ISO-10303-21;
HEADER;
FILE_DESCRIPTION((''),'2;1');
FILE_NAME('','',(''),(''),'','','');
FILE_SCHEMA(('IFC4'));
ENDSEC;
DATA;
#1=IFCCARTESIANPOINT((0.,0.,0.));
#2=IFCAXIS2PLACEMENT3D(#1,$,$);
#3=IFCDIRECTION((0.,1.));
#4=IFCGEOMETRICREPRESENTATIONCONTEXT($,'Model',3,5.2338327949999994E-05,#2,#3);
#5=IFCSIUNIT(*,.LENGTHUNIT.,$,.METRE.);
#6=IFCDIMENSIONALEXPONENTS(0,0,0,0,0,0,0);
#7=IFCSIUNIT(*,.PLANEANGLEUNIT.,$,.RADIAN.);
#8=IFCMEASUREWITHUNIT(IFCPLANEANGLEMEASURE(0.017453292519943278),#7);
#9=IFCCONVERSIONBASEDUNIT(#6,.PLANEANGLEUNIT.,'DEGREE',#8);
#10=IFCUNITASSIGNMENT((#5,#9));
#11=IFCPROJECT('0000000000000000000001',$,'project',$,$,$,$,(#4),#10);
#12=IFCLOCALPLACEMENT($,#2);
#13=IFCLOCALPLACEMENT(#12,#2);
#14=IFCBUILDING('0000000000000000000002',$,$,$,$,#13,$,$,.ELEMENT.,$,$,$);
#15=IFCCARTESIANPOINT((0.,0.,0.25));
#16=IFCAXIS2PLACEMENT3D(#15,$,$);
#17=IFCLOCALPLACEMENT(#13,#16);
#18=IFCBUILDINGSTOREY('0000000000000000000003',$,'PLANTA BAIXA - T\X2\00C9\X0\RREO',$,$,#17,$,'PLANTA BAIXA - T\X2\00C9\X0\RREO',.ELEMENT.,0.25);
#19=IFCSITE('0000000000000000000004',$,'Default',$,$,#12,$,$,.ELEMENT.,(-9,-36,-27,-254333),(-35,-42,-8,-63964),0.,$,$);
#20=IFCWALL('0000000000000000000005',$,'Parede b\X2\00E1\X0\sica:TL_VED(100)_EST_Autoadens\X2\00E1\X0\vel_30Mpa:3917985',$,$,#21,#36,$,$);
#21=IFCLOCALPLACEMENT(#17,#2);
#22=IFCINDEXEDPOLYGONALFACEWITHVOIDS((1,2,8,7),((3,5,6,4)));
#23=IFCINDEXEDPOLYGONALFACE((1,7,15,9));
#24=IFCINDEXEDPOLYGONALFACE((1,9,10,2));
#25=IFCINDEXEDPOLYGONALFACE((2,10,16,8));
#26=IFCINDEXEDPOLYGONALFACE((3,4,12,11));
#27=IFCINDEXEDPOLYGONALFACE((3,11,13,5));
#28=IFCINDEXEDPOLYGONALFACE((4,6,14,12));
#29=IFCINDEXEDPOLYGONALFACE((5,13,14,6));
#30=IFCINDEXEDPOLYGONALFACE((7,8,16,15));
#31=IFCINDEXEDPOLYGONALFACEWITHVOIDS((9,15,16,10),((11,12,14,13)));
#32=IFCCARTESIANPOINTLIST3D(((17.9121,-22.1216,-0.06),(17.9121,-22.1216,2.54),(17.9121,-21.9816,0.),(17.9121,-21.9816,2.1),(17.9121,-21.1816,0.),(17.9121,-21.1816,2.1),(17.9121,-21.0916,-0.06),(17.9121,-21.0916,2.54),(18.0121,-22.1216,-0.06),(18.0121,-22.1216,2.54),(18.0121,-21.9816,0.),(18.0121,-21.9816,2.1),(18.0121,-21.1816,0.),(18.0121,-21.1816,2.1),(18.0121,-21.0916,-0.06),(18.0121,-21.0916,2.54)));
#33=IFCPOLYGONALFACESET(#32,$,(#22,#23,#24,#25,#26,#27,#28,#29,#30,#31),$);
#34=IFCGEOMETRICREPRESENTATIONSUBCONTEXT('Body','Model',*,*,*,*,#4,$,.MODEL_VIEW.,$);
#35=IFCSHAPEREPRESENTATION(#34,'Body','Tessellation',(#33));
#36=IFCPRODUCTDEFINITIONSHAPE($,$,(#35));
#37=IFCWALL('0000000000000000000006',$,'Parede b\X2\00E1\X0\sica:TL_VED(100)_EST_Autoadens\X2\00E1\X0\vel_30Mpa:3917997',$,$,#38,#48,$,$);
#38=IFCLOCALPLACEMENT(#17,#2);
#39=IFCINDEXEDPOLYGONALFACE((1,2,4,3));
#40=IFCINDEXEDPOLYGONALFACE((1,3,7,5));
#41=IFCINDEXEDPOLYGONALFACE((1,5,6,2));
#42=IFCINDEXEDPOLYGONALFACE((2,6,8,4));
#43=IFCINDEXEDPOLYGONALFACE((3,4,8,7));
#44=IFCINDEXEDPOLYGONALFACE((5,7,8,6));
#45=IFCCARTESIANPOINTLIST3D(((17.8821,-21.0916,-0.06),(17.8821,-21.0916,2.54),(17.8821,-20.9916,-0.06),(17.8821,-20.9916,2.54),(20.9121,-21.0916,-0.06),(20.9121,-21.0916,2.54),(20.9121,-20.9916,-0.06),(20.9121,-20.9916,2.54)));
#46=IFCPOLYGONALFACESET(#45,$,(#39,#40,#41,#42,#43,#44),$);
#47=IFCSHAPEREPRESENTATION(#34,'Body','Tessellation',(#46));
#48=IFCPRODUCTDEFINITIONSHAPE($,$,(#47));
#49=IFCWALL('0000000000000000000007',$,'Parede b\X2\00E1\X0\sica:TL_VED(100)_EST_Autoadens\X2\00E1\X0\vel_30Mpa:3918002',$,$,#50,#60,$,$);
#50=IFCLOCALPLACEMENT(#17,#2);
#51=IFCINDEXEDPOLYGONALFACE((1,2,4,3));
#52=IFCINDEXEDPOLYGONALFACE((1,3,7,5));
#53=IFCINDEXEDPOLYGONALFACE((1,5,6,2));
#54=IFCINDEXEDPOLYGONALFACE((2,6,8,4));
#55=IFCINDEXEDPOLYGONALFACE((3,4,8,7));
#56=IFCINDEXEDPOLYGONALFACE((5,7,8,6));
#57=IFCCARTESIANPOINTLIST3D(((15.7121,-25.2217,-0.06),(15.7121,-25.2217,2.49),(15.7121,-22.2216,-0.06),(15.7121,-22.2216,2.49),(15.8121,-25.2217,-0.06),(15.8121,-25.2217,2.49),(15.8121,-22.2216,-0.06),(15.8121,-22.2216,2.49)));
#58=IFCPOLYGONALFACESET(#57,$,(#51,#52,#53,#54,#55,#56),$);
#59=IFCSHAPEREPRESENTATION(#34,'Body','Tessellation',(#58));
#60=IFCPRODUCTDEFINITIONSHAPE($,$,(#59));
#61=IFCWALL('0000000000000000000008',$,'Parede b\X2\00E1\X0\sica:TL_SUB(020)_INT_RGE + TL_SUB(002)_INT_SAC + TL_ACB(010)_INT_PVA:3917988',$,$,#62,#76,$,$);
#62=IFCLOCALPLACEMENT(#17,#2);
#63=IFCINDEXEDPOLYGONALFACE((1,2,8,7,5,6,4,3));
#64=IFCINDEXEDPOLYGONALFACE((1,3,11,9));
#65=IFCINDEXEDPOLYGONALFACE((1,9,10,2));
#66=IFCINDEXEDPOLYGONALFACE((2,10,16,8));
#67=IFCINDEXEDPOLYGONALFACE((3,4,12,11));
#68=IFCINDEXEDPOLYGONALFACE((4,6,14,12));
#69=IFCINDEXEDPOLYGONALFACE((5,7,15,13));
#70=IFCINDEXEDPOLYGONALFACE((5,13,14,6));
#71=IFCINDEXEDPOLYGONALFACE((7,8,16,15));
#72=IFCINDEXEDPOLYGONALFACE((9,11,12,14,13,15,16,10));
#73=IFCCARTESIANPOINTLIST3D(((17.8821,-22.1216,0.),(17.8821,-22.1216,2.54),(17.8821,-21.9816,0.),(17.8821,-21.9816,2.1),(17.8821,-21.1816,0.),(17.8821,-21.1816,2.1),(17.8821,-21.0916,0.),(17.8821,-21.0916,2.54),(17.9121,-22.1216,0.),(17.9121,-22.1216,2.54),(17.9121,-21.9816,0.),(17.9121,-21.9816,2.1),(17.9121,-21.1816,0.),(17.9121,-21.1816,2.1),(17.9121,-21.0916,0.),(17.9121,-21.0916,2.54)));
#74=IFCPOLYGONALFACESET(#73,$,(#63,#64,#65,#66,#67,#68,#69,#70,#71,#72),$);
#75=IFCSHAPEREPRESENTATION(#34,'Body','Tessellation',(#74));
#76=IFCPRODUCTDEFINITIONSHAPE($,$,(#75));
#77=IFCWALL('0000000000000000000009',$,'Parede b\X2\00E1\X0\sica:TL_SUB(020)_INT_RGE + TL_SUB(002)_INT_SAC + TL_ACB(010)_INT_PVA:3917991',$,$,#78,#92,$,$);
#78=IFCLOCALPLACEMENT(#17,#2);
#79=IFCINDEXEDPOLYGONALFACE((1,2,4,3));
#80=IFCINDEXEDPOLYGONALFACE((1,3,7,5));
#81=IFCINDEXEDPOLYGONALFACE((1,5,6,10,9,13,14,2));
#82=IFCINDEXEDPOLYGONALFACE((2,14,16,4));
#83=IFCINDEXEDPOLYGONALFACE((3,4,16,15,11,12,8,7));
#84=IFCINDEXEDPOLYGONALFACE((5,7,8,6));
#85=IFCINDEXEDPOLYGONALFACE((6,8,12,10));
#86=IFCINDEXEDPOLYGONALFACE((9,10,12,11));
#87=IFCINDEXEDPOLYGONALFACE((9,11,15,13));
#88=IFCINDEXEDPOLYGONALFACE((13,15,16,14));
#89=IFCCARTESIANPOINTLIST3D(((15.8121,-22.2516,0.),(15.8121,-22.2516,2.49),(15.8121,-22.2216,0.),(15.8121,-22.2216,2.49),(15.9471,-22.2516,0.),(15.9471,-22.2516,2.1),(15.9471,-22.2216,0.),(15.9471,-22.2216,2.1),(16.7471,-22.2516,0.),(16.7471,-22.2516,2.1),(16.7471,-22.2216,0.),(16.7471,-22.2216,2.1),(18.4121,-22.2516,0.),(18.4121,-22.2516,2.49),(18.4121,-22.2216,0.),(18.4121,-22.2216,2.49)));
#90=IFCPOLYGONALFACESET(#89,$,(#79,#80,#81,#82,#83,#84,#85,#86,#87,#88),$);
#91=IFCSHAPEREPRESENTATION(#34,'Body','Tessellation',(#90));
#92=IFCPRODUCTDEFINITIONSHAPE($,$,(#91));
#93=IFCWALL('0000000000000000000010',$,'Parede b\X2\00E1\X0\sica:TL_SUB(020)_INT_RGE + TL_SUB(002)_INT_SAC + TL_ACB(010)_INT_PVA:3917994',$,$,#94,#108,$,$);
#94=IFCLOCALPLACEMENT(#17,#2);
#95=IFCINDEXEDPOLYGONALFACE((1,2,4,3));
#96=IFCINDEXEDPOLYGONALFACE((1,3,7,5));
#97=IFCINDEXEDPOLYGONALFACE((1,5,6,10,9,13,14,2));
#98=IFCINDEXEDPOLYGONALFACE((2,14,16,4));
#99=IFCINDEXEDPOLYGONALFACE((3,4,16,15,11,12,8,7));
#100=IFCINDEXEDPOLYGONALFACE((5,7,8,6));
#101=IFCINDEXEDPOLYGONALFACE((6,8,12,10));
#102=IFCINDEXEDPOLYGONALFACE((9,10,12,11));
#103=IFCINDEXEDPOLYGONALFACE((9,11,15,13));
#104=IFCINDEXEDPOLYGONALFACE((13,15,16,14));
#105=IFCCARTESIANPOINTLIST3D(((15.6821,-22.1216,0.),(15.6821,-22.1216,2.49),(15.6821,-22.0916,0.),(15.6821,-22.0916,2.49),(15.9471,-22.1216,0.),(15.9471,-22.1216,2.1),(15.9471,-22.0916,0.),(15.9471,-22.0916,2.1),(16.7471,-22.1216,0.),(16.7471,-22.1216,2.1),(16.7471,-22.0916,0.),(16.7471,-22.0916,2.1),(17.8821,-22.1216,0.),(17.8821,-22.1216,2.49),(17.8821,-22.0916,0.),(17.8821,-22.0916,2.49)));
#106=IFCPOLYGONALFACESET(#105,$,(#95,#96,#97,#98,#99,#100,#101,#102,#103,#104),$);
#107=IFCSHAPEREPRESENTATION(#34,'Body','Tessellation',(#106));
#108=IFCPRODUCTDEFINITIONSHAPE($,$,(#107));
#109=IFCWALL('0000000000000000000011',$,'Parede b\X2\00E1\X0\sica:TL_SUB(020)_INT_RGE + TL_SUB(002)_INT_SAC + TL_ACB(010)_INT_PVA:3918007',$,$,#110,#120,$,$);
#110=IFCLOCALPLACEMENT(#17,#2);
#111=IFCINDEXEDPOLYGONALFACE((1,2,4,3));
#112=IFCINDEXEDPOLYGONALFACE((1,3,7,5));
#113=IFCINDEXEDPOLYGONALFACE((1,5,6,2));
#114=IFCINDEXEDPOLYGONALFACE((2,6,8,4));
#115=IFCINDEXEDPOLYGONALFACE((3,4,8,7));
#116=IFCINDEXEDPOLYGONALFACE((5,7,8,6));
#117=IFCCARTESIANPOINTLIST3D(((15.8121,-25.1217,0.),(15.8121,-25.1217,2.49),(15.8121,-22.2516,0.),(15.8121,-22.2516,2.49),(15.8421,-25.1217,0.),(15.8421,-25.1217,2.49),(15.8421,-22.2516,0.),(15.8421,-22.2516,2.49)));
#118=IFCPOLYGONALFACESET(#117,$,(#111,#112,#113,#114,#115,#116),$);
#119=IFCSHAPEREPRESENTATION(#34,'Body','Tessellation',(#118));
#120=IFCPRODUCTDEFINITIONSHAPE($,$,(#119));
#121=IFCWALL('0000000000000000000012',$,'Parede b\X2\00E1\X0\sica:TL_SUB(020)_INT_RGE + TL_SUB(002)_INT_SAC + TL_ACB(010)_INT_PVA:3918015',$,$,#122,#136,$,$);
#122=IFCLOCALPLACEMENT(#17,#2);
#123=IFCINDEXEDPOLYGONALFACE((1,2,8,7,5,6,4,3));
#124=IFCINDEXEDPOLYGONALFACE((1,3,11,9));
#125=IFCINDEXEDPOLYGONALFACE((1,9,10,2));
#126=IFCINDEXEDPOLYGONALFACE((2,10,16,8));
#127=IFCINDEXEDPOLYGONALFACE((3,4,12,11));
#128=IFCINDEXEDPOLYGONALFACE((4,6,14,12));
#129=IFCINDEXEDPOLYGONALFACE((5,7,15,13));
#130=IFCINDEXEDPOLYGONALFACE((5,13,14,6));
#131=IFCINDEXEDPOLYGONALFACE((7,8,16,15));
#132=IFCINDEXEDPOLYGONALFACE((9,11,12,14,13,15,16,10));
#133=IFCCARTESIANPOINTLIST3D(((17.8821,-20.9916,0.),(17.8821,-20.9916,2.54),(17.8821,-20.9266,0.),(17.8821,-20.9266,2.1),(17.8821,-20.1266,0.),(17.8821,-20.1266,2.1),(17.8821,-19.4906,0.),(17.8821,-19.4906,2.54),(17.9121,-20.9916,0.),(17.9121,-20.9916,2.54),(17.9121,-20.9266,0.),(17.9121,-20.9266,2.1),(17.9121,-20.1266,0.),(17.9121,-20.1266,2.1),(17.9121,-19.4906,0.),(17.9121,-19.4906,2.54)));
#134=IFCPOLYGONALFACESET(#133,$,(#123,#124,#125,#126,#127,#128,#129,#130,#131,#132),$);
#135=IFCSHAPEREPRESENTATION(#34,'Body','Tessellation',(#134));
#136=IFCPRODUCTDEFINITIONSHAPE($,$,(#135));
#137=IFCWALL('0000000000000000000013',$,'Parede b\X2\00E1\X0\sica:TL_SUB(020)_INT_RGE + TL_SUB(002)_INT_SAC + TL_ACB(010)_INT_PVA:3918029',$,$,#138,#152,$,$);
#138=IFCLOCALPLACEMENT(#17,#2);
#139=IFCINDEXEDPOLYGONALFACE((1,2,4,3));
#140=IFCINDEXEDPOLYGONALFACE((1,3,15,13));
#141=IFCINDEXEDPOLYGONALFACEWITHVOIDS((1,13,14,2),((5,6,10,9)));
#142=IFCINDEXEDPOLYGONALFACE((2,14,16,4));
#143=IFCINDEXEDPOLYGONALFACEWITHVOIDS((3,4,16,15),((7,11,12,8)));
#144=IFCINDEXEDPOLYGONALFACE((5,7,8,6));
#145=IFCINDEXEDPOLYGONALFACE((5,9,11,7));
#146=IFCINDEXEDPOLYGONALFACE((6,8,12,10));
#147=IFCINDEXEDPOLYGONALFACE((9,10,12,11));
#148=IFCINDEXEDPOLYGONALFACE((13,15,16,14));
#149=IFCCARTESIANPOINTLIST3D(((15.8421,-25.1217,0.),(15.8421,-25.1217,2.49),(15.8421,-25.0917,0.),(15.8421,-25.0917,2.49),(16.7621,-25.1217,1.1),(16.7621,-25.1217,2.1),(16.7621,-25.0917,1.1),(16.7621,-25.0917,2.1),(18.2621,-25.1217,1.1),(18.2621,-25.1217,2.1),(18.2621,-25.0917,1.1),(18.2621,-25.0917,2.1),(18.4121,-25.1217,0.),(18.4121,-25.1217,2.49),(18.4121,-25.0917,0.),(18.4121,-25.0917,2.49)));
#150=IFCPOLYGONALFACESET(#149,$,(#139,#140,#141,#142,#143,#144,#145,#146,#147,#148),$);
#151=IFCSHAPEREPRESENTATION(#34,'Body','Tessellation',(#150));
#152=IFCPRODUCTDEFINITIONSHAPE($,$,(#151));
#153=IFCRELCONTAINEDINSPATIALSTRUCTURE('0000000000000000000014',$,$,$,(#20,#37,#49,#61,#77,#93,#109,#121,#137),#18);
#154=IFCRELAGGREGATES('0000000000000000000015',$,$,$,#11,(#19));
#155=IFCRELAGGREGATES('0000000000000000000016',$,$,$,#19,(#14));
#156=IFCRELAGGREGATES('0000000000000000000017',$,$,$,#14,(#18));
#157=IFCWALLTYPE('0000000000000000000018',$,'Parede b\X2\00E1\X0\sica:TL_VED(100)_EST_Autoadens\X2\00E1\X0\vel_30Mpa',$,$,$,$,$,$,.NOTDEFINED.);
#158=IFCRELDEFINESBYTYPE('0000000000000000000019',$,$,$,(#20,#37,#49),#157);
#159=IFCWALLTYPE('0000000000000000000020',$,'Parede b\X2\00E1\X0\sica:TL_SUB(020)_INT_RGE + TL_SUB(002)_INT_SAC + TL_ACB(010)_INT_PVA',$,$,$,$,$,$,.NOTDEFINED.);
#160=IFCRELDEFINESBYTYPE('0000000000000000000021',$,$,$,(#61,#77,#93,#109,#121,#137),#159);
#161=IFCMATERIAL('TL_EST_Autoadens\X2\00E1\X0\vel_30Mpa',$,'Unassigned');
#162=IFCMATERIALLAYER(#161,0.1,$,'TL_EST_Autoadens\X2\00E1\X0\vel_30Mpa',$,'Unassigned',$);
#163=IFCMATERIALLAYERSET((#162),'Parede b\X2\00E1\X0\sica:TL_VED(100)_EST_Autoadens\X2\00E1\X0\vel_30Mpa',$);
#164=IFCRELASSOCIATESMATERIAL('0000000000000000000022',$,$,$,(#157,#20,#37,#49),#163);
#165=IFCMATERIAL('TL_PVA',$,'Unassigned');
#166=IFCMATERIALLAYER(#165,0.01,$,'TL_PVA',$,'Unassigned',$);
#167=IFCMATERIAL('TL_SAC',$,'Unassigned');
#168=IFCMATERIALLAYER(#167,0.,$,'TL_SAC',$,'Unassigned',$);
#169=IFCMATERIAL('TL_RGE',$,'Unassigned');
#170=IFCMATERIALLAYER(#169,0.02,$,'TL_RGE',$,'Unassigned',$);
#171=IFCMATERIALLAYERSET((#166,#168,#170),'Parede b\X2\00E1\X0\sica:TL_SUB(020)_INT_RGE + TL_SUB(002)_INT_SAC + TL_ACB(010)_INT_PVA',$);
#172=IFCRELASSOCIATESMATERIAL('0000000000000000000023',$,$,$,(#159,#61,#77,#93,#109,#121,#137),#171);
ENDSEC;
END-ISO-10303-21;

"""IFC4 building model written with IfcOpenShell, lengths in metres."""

from ifc_helpers import new_model, entity, si_unit, converted_unit, direction, frame, frame_2d, origin, place, context, subcontext, project, spatial, rectangle, extrude, material, layer, layer_set, layer_usage, type_object, element, save


model = new_model("IFC4")

# Units and contexts
model_context = context("Model", 3, precision=5.2338327949999994e-05, world=origin(), true_north=direction((0.0, 1.0)))
body_context = subcontext(model_context, "Body", "Model", "MODEL_VIEW")
ifc_project = project(units=[si_unit("LENGTHUNIT", "METRE"), converted_unit("PLANEANGLEUNIT", "DEGREE", entity("IfcPlaneAngleMeasure", 0.017453292519943278), si_unit("PLANEANGLEUNIT", "RADIAN"), dimensions=[0, 0, 0, 0, 0, 0, 0])], contexts=[model_context])

# Site, building, storey
site_placement = place(None, frame((0.0, 0.0, 0.0)))
site = spatial("IfcSite", under=ifc_project, at=site_placement, Name="Default", CompositionType="ELEMENT", RefLatitude=(-9, -36, -27, -254333), RefLongitude=(-35, -42, -8, -63964), RefElevation=0.0)
building_placement = place(site_placement, origin())
building = spatial("IfcBuilding", under=site, at=building_placement, CompositionType="ELEMENT")
storey_placement = place(building_placement, frame((0.0, 0.0, 0.25)))
storey = spatial("IfcBuildingStorey", under=building, at=storey_placement, Name="PLANTA BAIXA - TÉRREO", LongName="PLANTA BAIXA - TÉRREO", CompositionType="ELEMENT", Elevation=0.25)

# Wall, opening
ifc_material_1 = material(Name="TL_EST_Autoadensável_30Mpa", Category="Unassigned")
ifc_layer_1 = layer(ifc_material_1, 0.1, Name="TL_EST_Autoadensável_30Mpa", Category="Unassigned")
ifc_layer_set_1 = layer_set([ifc_layer_1], Name="Parede básica:TL_VED(100)_EST_Autoadensável_30Mpa")
ifc_layer_usage_1 = layer_usage(ifc_layer_set_1, "AXIS2", "POSITIVE", -0.05)
wall_type_1 = type_object("IfcWallType", Name="Parede básica:TL_VED(100)_EST_Autoadensável_30Mpa", PredefinedType="NOTDEFINED", material=ifc_layer_set_1)
wall_1_placement = place(storey_placement, frame((17.9621, -22.1216, -0.06), z_axis=(0.0, 0.0, 1.0), x_axis=(0.0, 1.0, 0.0)))
wall_1 = element("IfcWall", 1, at=wall_1_placement, inside=storey, type_object=wall_type_1, material=ifc_layer_usage_1, Name="Parede básica:TL_VED(100)_EST_Autoadensável_30Mpa:3917985", context=body_context, shape_type="SweptSolid", body=[
    extrude(rectangle(XDim=1.03, YDim=0.1, at=frame_2d((0.515, 0.0), x_axis=(-1.0, 0.0))), origin(), (0.0, 0.0, 1.0), 2.6),
])
opening_1_placement = place(wall_1_placement, frame((0.94, 0.05, 0.06)))
element("IfcOpeningElement", 2, at=opening_1_placement, cuts=wall_1, PredefinedType="OPENING", context=body_context, shape_type="SweptSolid", body=[
    extrude(rectangle(XDim=2.1, YDim=0.8, at=frame_2d((1.05, 0.4), x_axis=(1.0, 0.0))), frame((0.0, 0.0, 0.0), z_axis=(0.0, -1.0, 0.0), x_axis=(0.0, 0.0, 1.0)), (0.0, 0.0, 1.0), 0.1),
])

# Wall
ifc_layer_usage_2 = layer_usage(ifc_layer_set_1, "AXIS2", "NEGATIVE", 0.05)
wall_2_placement = place(storey_placement, frame((17.8821, -21.0416, -0.06)))
element("IfcWall", 3, at=wall_2_placement, inside=storey, type_object=wall_type_1, material=ifc_layer_usage_2, Name="Parede básica:TL_VED(100)_EST_Autoadensável_30Mpa:3917997", context=body_context, shape_type="SweptSolid", body=[
    extrude(rectangle(XDim=3.03, YDim=0.1, at=frame_2d((1.515, 0.0), x_axis=(-1.0, 0.0))), origin(), (0.0, 0.0, 1.0), 2.6),
])

# Walls, openings
ifc_layer_usage_3 = layer_usage(ifc_layer_set_1, "AXIS2", "NEGATIVE", 0.05)
wall_3_placement = place(storey_placement, frame((15.7621, -25.2217, -0.06), z_axis=(0.0, 0.0, 1.0), x_axis=(0.0, 1.0, 0.0)))
wall_3 = element("IfcWall", 4, at=wall_3_placement, inside=storey, type_object=wall_type_1, material=ifc_layer_usage_3, Name="Parede básica:TL_VED(100)_EST_Autoadensável_30Mpa:3918002", context=body_context, shape_type="SweptSolid", body=[
    extrude(rectangle(XDim=3.0001, YDim=0.1, at=frame_2d((1.5001, 0.0), x_axis=(-1.0, 0.0))), origin(), (0.0, 0.0, 1.0), 2.55),
])
opening_2_placement = place(wall_3_placement, frame((25.2217, 15.7621, 0.06)))
element("IfcOpeningElement", 5, at=opening_2_placement, cuts=wall_3, PredefinedType="OPENING", context=body_context, shape_type="SweptSolid", body=[
    extrude(rectangle(XDim=2.1, YDim=0.1, at=frame_2d((0.0, 0.0), x_axis=(0.0, 1.0))), frame((-24.2717, -15.7121, 1.05), z_axis=(0.0, 1.0, 0.0), x_axis=(1.0, 0.0, 0.0)), (0.0, 0.0, 1.0), 2.4),
])
ifc_material_2 = material(Name="TL_PVA", Category="Unassigned")
ifc_layer_2 = layer(ifc_material_2, 0.01, Name="TL_PVA", Category="Unassigned")
ifc_material_3 = material(Name="TL_SAC", Category="Unassigned")
ifc_layer_3 = layer(ifc_material_3, 0.0, Name="TL_SAC", Category="Unassigned")
ifc_material_4 = material(Name="TL_RGE", Category="Unassigned")
ifc_layer_4 = layer(ifc_material_4, 0.02, Name="TL_RGE", Category="Unassigned")
ifc_layer_set_2 = layer_set([ifc_layer_2, ifc_layer_3, ifc_layer_4], Name="Parede básica:TL_SUB(020)_INT_RGE + TL_SUB(002)_INT_SAC + TL_ACB(010)_INT_PVA")
ifc_layer_usage_4 = layer_usage(ifc_layer_set_2, "AXIS2", "POSITIVE", -0.015)
wall_type_2 = type_object("IfcWallType", Name="Parede básica:TL_SUB(020)_INT_RGE + TL_SUB(002)_INT_SAC + TL_ACB(010)_INT_PVA", PredefinedType="NOTDEFINED", material=ifc_layer_set_2)
wall_4_placement = place(storey_placement, frame((17.8971, -21.0916, 0.0), z_axis=(0.0, 0.0, 1.0), x_axis=(0.0, -1.0, 0.0)))
wall_4 = element("IfcWall", 6, at=wall_4_placement, inside=storey, type_object=wall_type_2, material=ifc_layer_usage_4, Name="Parede básica:TL_SUB(020)_INT_RGE + TL_SUB(002)_INT_SAC + TL_ACB(010)_INT_PVA:3917988", context=body_context, shape_type="SweptSolid", body=[
    extrude(rectangle(XDim=1.03, YDim=0.03, at=frame_2d((0.515, 0.0), x_axis=(-1.0, 0.0))), origin(), (0.0, 0.0, 1.0), 2.54),
])
opening_3_placement = place(wall_4_placement, frame((-21.0916, -17.8971, 0.0)))
element("IfcOpeningElement", 7, at=opening_3_placement, cuts=wall_4, PredefinedType="OPENING", context=body_context, shape_type="SweptSolid", body=[
    extrude(rectangle(XDim=2.1, YDim=0.8, at=frame_2d((0.0, 0.0), x_axis=(1.0, 0.0))), frame((21.5816, 16.3881, 1.05), z_axis=(0.0, 1.0, 0.0), x_axis=(0.0, 0.0, 1.0)), (0.0, 0.0, 1.0), 3.048),
])
ifc_layer_usage_5 = layer_usage(ifc_layer_set_2, "AXIS2", "POSITIVE", -0.015)
wall_5_placement = place(storey_placement, frame((15.8121, -22.2366, 0.0)))
wall_5 = element("IfcWall", 8, at=wall_5_placement, inside=storey, type_object=wall_type_2, material=ifc_layer_usage_5, Name="Parede básica:TL_SUB(020)_INT_RGE + TL_SUB(002)_INT_SAC + TL_ACB(010)_INT_PVA:3917991", context=body_context, shape_type="SweptSolid", body=[
    extrude(rectangle(XDim=2.6, YDim=0.03, at=frame_2d((1.3, 0.0), x_axis=(-1.0, 0.0))), origin(), (0.0, 0.0, 1.0), 2.49),
])
opening_4_placement = place(wall_5_placement, frame((-15.8121, 22.2366, 0.0)))
element("IfcOpeningElement", 9, at=opening_4_placement, cuts=wall_5, PredefinedType="OPENING", context=body_context, shape_type="SweptSolid", body=[
    extrude(rectangle(XDim=2.1, YDim=0.8, at=frame_2d((0.0, 0.0), x_axis=(1.0, 0.0))), frame((16.3471, -23.6456, 1.05), z_axis=(0.0, 1.0, 0.0), x_axis=(0.0, 0.0, 1.0)), (0.0, 0.0, 1.0), 3.048),
])
ifc_layer_usage_6 = layer_usage(ifc_layer_set_2, "AXIS2", "POSITIVE", -0.015)
wall_6_placement = place(storey_placement, frame((17.8821, -22.1066, 0.0), z_axis=(0.0, 0.0, 1.0), x_axis=(-1.0, 0.0, 0.0)))
wall_6 = element("IfcWall", 10, at=wall_6_placement, inside=storey, type_object=wall_type_2, material=ifc_layer_usage_6, Name="Parede básica:TL_SUB(020)_INT_RGE + TL_SUB(002)_INT_SAC + TL_ACB(010)_INT_PVA:3917994", context=body_context, shape_type="SweptSolid", body=[
    extrude(rectangle(XDim=2.2, YDim=0.03, at=frame_2d((1.1, 0.0), x_axis=(1.0, 0.0))), origin(), (0.0, 0.0, 1.0), 2.49),
])
opening_5_placement = place(wall_6_placement, frame((17.8821, -22.1066, 0.0)))
element("IfcOpeningElement", 11, at=opening_5_placement, cuts=wall_6, PredefinedType="OPENING", context=body_context, shape_type="SweptSolid", body=[
    extrude(rectangle(XDim=2.1, YDim=0.8, at=frame_2d((0.0, 0.0), x_axis=(0.0, 1.0))), frame((-16.3471, 20.5976, 1.05), z_axis=(0.0, 1.0, 0.0), x_axis=(-1.0, 0.0, 0.0)), (0.0, 0.0, 1.0), 3.048),
])

# Wall
ifc_layer_usage_7 = layer_usage(ifc_layer_set_2, "AXIS2", "NEGATIVE", 0.015)
wall_7_placement = place(storey_placement, frame((15.8271, -22.2516, 0.0), z_axis=(0.0, 0.0, 1.0), x_axis=(0.0, -1.0, 0.0)))
element("IfcWall", 12, at=wall_7_placement, inside=storey, type_object=wall_type_2, material=ifc_layer_usage_7, Name="Parede básica:TL_SUB(020)_INT_RGE + TL_SUB(002)_INT_SAC + TL_ACB(010)_INT_PVA:3918007", context=body_context, shape_type="SweptSolid", body=[
    extrude(rectangle(XDim=2.8701, YDim=0.03, at=frame_2d((1.4351, 0.0), x_axis=(-1.0, 0.0))), origin(), (0.0, 0.0, 1.0), 2.49),
])

# Walls, openings
ifc_layer_usage_8 = layer_usage(ifc_layer_set_2, "AXIS2", "NEGATIVE", 0.015)
wall_8_placement = place(storey_placement, frame((17.8971, -20.9916, 0.0), z_axis=(0.0, 0.0, 1.0), x_axis=(0.0, 1.0, 0.0)))
wall_8 = element("IfcWall", 13, at=wall_8_placement, inside=storey, type_object=wall_type_2, material=ifc_layer_usage_8, Name="Parede básica:TL_SUB(020)_INT_RGE + TL_SUB(002)_INT_SAC + TL_ACB(010)_INT_PVA:3918015", context=body_context, shape_type="SweptSolid", body=[
    extrude(rectangle(XDim=1.501, YDim=0.03, at=frame_2d((0.7505, 0.0), x_axis=(-1.0, 0.0))), origin(), (0.0, 0.0, 1.0), 2.54),
])
opening_6_placement = place(wall_8_placement, frame((0.865, 0.015, 0.0)))
element("IfcOpeningElement", 14, at=opening_6_placement, cuts=wall_8, PredefinedType="OPENING", context=body_context, shape_type="SweptSolid", body=[
    extrude(rectangle(XDim=2.1, YDim=0.8, at=frame_2d((1.05, 0.4), x_axis=(1.0, 0.0))), frame((0.0, 0.0, 0.0), z_axis=(0.0, -1.0, 0.0), x_axis=(0.0, 0.0, 1.0)), (0.0, 0.0, 1.0), 0.03),
])
ifc_layer_usage_9 = layer_usage(ifc_layer_set_2, "AXIS2", "NEGATIVE", 0.015)
wall_9_placement = place(storey_placement, frame((15.8421, -25.1067, 0.0)))
wall_9 = element("IfcWall", 15, at=wall_9_placement, inside=storey, type_object=wall_type_2, material=ifc_layer_usage_9, Name="Parede básica:TL_SUB(020)_INT_RGE + TL_SUB(002)_INT_SAC + TL_ACB(010)_INT_PVA:3918029", context=body_context, shape_type="SweptSolid", body=[
    extrude(rectangle(XDim=2.57, YDim=0.03, at=frame_2d((1.285, 0.0), x_axis=(-1.0, 0.0))), origin(), (0.0, 0.0, 1.0), 2.49),
])
opening_7_placement = place(wall_9_placement, frame((-15.8421, 25.1067, 1.1)))
element("IfcOpeningElement", 16, at=opening_7_placement, cuts=wall_9, PredefinedType="OPENING", context=body_context, shape_type="SweptSolid", body=[
    extrude(rectangle(XDim=1.0, YDim=1.5, at=frame_2d((0.0, 0.0), x_axis=(0.0, 1.0))), frame((17.5121, -26.6457, 0.5), z_axis=(0.0, 1.0, 0.0), x_axis=(1.0, 0.0, 0.0)), (0.0, 0.0, 1.0), 3.048),
])

save(model, "model.ifc")
